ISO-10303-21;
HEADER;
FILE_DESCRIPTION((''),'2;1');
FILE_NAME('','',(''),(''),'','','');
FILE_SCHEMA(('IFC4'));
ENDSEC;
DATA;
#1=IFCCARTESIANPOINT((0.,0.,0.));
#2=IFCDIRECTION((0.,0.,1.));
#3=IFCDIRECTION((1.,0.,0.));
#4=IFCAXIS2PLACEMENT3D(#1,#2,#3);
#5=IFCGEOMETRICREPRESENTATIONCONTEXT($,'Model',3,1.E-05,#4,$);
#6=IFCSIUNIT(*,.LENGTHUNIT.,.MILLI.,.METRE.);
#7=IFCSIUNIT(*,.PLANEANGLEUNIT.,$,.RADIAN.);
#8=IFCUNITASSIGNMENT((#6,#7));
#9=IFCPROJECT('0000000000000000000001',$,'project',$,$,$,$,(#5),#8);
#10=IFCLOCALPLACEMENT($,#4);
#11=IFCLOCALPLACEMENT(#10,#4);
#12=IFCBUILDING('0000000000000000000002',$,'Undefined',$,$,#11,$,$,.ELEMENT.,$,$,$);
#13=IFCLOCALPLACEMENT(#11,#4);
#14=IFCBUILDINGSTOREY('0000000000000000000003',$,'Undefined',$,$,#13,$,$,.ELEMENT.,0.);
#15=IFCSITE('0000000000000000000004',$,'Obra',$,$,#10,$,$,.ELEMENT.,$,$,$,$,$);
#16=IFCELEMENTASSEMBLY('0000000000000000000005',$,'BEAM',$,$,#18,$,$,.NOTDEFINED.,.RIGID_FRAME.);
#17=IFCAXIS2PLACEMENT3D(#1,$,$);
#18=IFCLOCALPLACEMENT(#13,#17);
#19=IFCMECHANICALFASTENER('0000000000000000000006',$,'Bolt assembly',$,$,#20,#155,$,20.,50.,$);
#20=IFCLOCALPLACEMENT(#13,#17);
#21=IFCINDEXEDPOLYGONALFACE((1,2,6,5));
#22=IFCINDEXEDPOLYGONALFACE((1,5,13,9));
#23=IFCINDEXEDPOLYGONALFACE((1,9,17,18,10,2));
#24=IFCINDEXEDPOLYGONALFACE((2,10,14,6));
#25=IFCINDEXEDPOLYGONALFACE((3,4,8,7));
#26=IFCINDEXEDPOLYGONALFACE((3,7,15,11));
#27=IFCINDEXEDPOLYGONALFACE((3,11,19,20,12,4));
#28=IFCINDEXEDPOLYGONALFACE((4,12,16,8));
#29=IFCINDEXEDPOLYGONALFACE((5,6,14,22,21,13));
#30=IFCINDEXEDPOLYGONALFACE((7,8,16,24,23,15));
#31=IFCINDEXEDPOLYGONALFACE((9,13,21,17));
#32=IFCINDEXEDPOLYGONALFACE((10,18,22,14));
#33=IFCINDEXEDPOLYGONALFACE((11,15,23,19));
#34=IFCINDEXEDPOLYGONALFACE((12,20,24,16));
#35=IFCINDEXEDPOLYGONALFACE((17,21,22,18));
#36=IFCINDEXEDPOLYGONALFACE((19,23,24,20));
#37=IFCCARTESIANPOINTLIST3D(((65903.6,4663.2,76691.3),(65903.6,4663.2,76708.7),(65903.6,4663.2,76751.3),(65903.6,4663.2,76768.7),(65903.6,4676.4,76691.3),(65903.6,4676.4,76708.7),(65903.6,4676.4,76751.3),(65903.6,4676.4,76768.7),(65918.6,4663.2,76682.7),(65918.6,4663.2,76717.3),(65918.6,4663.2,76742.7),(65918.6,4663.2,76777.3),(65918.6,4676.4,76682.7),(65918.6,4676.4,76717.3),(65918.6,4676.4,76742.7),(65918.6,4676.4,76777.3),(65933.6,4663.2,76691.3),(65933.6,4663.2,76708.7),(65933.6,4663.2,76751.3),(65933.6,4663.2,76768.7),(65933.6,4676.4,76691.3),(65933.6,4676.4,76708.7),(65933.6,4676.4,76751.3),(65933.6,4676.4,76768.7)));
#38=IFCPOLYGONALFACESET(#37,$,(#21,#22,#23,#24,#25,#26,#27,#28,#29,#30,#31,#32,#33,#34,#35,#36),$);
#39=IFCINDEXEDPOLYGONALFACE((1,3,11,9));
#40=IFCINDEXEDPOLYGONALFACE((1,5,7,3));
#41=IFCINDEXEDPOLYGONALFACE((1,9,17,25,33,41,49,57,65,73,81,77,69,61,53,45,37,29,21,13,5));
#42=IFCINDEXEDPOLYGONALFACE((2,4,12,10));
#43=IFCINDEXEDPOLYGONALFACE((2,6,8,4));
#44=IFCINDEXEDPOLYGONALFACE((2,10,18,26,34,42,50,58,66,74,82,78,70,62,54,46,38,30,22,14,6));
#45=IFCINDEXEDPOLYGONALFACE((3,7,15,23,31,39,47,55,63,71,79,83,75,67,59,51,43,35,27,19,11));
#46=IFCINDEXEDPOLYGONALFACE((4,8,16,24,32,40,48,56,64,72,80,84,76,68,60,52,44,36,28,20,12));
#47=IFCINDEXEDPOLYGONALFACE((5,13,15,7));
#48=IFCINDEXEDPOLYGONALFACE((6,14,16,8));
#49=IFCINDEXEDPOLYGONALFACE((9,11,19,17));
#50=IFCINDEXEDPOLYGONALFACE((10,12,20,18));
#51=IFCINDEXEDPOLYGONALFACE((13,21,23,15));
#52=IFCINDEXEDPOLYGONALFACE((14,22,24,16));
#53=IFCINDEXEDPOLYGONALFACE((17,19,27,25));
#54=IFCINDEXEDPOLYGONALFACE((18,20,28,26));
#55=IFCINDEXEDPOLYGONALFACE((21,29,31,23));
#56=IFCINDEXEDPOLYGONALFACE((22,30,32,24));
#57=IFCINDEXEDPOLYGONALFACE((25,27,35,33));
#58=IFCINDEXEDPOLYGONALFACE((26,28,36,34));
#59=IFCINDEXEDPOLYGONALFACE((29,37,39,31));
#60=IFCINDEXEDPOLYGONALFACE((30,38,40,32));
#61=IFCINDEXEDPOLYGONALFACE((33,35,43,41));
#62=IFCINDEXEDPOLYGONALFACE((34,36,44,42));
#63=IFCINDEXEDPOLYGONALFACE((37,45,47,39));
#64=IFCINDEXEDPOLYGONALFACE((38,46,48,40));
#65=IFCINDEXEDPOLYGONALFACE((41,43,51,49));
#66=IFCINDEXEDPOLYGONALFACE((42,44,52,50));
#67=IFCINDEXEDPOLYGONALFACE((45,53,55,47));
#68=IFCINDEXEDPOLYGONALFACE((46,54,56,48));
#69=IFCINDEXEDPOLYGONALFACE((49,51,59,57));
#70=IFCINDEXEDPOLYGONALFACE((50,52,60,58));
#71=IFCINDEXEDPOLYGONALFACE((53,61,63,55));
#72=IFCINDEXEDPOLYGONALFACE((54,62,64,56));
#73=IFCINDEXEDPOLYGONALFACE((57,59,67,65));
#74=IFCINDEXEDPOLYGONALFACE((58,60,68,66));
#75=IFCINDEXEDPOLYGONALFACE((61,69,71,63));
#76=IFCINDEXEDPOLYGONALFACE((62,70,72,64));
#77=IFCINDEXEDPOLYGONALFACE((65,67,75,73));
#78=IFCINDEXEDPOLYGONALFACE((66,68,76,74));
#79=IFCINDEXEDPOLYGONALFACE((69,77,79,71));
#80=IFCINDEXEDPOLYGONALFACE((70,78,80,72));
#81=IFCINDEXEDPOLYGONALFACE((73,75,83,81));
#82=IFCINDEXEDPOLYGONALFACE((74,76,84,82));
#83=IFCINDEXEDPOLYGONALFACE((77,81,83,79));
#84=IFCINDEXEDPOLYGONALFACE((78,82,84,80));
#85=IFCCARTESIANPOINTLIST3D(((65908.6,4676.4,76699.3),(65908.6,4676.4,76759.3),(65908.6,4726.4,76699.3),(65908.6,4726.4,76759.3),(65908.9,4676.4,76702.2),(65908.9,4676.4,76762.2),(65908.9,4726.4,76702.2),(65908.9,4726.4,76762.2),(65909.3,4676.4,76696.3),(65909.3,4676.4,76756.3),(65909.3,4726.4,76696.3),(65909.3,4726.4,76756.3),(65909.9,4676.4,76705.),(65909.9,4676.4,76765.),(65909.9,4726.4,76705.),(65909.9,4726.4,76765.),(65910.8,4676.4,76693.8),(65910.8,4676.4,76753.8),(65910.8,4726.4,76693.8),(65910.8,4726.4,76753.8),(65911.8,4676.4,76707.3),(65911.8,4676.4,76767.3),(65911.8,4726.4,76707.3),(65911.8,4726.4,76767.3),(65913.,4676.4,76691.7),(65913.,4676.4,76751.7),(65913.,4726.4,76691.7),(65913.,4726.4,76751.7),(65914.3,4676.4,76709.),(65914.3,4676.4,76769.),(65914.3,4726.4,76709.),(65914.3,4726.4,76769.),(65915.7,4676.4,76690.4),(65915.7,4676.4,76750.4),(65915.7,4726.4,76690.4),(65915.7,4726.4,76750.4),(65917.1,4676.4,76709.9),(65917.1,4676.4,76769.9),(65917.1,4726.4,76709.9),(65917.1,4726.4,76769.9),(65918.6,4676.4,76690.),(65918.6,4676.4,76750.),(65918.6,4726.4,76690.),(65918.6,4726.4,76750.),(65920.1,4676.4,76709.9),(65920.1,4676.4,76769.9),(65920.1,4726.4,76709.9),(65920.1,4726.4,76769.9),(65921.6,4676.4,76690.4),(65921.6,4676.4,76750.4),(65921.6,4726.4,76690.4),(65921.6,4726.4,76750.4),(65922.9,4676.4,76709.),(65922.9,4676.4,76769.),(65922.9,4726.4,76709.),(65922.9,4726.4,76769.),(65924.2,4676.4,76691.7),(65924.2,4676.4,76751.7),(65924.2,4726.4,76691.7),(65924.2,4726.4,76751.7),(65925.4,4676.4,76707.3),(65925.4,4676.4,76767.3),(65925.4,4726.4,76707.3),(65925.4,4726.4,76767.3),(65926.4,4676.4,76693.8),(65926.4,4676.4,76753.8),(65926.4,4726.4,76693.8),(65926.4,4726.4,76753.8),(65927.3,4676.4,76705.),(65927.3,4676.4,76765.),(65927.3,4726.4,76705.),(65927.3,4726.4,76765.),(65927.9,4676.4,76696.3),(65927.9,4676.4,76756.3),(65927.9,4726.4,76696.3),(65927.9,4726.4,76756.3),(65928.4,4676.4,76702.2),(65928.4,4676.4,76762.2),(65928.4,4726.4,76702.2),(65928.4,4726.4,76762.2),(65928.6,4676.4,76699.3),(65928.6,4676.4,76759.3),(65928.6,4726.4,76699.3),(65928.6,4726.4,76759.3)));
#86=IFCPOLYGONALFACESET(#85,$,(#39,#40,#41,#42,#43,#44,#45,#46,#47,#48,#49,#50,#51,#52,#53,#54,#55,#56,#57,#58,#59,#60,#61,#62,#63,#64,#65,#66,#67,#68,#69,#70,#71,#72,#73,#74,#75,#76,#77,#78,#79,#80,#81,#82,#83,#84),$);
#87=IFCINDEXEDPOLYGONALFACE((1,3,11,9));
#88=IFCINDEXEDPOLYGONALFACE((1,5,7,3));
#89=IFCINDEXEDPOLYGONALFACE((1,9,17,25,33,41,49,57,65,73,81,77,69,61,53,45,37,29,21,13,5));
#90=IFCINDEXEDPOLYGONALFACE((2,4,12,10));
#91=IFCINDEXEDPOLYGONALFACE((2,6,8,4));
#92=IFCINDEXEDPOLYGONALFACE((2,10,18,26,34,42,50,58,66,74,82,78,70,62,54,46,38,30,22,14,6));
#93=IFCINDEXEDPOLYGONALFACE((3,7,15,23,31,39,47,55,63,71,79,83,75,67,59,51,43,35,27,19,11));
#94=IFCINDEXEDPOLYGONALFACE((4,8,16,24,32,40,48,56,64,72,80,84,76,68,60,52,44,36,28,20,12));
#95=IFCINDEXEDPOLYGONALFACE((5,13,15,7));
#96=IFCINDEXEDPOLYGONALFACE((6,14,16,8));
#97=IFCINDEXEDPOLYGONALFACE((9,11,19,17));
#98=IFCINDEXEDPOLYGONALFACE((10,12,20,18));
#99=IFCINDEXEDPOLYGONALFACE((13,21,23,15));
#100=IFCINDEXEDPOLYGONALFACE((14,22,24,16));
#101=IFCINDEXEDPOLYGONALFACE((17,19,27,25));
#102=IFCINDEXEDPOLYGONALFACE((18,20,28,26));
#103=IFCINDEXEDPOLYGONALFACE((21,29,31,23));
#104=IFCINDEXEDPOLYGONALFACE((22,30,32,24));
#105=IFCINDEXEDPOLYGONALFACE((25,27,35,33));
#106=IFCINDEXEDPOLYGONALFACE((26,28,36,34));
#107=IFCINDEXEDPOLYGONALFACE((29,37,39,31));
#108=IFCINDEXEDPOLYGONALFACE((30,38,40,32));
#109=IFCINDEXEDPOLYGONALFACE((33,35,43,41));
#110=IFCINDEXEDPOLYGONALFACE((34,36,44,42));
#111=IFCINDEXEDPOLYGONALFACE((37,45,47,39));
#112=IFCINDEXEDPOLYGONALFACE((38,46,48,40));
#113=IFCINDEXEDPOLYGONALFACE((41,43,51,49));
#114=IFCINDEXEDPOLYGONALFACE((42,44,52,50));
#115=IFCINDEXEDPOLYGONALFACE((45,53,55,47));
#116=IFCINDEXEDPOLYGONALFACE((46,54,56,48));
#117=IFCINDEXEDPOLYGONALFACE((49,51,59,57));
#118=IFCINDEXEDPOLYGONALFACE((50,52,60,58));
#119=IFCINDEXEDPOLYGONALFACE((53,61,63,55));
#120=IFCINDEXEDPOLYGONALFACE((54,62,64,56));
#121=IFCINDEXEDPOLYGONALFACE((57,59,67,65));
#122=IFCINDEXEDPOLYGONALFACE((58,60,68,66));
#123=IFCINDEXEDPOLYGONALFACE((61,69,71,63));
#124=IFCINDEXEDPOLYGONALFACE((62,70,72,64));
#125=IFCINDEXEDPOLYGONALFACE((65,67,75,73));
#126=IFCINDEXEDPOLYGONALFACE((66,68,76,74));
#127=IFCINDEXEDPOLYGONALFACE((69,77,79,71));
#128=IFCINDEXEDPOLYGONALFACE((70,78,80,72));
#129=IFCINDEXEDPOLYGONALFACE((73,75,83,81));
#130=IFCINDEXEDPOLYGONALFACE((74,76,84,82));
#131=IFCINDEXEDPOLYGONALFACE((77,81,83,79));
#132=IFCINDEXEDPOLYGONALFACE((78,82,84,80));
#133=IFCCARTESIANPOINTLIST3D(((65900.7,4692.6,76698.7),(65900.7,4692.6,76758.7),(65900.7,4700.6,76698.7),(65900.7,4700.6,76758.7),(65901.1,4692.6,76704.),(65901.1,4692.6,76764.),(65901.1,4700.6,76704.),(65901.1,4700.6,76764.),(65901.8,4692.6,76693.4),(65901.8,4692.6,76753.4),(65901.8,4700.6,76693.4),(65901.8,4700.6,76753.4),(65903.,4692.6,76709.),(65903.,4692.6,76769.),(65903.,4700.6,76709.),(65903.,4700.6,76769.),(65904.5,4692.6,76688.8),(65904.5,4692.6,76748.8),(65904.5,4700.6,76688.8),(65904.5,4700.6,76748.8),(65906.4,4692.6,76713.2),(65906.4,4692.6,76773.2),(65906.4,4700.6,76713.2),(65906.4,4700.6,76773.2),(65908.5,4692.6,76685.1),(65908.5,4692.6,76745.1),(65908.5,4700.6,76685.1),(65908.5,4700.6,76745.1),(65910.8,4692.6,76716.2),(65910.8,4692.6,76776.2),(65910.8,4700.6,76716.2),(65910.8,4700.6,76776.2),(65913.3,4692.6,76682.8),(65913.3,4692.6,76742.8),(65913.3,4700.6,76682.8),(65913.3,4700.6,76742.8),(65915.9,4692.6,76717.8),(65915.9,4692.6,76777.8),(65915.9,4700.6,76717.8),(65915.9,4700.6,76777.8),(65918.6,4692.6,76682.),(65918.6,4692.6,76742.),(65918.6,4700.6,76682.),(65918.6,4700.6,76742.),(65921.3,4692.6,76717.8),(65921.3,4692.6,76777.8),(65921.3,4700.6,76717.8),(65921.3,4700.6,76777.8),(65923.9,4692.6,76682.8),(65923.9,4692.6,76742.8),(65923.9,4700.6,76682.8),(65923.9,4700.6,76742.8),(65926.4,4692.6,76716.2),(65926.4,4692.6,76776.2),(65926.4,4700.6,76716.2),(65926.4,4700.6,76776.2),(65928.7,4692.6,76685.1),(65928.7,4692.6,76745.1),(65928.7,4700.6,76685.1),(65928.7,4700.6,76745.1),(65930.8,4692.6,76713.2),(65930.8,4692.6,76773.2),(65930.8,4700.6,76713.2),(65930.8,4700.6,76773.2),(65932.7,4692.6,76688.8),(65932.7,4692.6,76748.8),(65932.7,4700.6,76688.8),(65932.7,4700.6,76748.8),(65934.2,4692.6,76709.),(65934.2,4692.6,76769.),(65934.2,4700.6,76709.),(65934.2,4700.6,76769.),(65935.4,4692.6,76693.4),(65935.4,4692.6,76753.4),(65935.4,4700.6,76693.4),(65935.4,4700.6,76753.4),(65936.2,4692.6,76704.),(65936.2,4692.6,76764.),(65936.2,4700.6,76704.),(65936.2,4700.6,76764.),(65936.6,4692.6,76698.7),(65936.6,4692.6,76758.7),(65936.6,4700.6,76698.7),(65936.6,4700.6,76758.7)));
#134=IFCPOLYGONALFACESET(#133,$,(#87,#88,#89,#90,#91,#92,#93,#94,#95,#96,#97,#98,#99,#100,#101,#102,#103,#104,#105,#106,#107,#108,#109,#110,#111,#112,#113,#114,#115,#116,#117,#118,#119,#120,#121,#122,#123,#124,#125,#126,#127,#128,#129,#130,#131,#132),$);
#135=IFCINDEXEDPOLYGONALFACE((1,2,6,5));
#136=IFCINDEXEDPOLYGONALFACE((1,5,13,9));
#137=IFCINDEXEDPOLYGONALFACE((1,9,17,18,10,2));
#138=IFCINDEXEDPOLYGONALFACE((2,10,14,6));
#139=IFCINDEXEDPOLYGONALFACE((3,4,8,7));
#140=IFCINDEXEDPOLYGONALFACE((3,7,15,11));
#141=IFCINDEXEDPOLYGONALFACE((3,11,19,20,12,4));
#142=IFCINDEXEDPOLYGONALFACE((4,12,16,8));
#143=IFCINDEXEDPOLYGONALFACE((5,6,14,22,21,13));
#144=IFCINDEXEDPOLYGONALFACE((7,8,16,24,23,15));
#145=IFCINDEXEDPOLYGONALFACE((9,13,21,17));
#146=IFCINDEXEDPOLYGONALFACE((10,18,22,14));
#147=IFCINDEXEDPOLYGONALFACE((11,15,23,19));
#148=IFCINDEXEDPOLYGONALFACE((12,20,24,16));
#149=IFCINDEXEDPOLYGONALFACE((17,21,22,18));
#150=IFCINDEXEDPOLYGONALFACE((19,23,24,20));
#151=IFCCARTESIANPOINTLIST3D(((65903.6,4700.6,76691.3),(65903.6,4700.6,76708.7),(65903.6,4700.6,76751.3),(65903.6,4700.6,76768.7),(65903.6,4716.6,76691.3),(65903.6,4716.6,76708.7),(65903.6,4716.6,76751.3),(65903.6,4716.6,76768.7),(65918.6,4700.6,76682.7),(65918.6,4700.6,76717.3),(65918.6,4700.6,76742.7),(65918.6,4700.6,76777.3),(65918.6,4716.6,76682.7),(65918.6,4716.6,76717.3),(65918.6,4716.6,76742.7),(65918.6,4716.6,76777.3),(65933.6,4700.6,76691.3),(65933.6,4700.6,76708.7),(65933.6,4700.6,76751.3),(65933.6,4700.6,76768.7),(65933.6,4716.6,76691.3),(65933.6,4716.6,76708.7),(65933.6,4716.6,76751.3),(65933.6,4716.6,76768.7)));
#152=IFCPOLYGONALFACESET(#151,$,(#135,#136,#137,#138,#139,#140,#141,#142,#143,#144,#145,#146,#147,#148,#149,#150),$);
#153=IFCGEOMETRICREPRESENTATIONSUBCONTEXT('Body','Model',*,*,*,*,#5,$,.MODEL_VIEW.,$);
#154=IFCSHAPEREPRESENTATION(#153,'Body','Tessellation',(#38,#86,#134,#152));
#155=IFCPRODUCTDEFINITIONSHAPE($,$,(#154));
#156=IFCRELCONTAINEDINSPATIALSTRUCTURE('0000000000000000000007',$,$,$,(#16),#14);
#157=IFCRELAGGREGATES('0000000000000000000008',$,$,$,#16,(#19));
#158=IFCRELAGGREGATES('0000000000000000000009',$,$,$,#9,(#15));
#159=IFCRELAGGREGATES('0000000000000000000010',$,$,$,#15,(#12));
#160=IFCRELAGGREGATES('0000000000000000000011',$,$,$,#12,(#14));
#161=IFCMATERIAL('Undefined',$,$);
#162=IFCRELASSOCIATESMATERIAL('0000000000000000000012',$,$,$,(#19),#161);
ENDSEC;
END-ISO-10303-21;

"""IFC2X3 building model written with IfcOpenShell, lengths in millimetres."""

from ifc_helpers import new_model, si_unit, frame, origin_with_axes, origin_2d_with_axis, place, context, subcontext, project, spatial, polyline, circle, outline, extrude, source, transform, mapped, material, element, aggregate, save


model = new_model("IFC2X3")

# Units and contexts
model_context = context("Model", 3, precision=1e-05, world=origin_with_axes())
body_context = subcontext(model_context, "Body", "Model", "MODEL_VIEW")
ifc_project = project(units=[si_unit("LENGTHUNIT", "METRE", prefix="MILLI"), si_unit("PLANEANGLEUNIT", "RADIAN")], contexts=[model_context])

# Site, building, storey
site_placement = place(None, origin_with_axes())
site = spatial("IfcSite", under=ifc_project, at=site_placement, Name="Obra", CompositionType="ELEMENT")
building_placement = place(site_placement, origin_with_axes())
building = spatial("IfcBuilding", under=site, at=building_placement, Name="Undefined", CompositionType="ELEMENT")
storey_placement = place(building_placement, origin_with_axes())
storey = spatial("IfcBuildingStorey", under=building, at=storey_placement, Name="Undefined", CompositionType="ELEMENT", Elevation=0.0)

# Element assembly
assembly_1_placement = place(storey_placement, origin_with_axes())
assembly_1 = element("IfcElementAssembly", 1, at=assembly_1_placement, inside=storey, Name="BEAM", AssemblyPlace="NOTDEFINED", PredefinedType="RIGID_FRAME")

# Mechanical fastener
ifc_material_1 = material(Name="Undefined")
shared_shape_1 = source(origin_with_axes(), body_context, "Body", "SweptSolid", [
    extrude(outline(polyline([(17.3, 0.0), (8.7, 15.0), (-8.7, 15.0), (-17.3, 0.0), (-8.7, -15.0), (8.7, -15.0), (17.3, 0.0)])), frame((0.0, -26.3, 0.0), z_axis=(0.0, 1.0, 0.0), x_axis=(1.0, 0.0, 0.0)), (0.0, 0.0, 1.0), 13.2),
    extrude(circle(Radius=10.0, at=origin_2d_with_axis()), frame((0.0, -13.1, 0.0), z_axis=(0.0, 1.0, 0.0), x_axis=(1.0, 0.0, 0.0)), (0.0, 0.0, 1.0), 50.0),
    extrude(circle(Radius=18.0, at=origin_2d_with_axis()), frame((0.0, 3.1, 0.0), z_axis=(0.0, 1.0, 0.0), x_axis=(1.0, 0.0, 0.0)), (0.0, 0.0, 1.0), 8.0),
    extrude(outline(polyline([(17.3, 0.0), (8.7, 15.0), (-8.7, 15.0), (-17.3, 0.0), (-8.7, -15.0), (8.7, -15.0), (17.3, 0.0)])), frame((0.0, 11.1, 0.0), z_axis=(0.0, 1.0, 0.0), x_axis=(1.0, 0.0, 0.0)), (0.0, 0.0, 1.0), 16.0),
])
mechanical_fastener_1_placement = place(assembly_1_placement, frame((65878.6, 4689.5, 76850.0), z_axis=(1.0, 0.0, 0.0), x_axis=(0.0, 0.0, -1.0)))
mechanical_fastener_1 = element("IfcMechanicalFastener", 2, at=mechanical_fastener_1_placement, material=ifc_material_1, Name="Bolt assembly", NominalDiameter=20.0, NominalLength=50.0, context=body_context, shape_type="MappedRepresentation", body=[
    mapped(shared_shape_1, transform((90.0, 0.0, 40.0))),
    mapped(shared_shape_1, transform((150.0, 0.0, 40.0))),
])

aggregate(assembly_1, [mechanical_fastener_1])

save(model, "model.ifc")
